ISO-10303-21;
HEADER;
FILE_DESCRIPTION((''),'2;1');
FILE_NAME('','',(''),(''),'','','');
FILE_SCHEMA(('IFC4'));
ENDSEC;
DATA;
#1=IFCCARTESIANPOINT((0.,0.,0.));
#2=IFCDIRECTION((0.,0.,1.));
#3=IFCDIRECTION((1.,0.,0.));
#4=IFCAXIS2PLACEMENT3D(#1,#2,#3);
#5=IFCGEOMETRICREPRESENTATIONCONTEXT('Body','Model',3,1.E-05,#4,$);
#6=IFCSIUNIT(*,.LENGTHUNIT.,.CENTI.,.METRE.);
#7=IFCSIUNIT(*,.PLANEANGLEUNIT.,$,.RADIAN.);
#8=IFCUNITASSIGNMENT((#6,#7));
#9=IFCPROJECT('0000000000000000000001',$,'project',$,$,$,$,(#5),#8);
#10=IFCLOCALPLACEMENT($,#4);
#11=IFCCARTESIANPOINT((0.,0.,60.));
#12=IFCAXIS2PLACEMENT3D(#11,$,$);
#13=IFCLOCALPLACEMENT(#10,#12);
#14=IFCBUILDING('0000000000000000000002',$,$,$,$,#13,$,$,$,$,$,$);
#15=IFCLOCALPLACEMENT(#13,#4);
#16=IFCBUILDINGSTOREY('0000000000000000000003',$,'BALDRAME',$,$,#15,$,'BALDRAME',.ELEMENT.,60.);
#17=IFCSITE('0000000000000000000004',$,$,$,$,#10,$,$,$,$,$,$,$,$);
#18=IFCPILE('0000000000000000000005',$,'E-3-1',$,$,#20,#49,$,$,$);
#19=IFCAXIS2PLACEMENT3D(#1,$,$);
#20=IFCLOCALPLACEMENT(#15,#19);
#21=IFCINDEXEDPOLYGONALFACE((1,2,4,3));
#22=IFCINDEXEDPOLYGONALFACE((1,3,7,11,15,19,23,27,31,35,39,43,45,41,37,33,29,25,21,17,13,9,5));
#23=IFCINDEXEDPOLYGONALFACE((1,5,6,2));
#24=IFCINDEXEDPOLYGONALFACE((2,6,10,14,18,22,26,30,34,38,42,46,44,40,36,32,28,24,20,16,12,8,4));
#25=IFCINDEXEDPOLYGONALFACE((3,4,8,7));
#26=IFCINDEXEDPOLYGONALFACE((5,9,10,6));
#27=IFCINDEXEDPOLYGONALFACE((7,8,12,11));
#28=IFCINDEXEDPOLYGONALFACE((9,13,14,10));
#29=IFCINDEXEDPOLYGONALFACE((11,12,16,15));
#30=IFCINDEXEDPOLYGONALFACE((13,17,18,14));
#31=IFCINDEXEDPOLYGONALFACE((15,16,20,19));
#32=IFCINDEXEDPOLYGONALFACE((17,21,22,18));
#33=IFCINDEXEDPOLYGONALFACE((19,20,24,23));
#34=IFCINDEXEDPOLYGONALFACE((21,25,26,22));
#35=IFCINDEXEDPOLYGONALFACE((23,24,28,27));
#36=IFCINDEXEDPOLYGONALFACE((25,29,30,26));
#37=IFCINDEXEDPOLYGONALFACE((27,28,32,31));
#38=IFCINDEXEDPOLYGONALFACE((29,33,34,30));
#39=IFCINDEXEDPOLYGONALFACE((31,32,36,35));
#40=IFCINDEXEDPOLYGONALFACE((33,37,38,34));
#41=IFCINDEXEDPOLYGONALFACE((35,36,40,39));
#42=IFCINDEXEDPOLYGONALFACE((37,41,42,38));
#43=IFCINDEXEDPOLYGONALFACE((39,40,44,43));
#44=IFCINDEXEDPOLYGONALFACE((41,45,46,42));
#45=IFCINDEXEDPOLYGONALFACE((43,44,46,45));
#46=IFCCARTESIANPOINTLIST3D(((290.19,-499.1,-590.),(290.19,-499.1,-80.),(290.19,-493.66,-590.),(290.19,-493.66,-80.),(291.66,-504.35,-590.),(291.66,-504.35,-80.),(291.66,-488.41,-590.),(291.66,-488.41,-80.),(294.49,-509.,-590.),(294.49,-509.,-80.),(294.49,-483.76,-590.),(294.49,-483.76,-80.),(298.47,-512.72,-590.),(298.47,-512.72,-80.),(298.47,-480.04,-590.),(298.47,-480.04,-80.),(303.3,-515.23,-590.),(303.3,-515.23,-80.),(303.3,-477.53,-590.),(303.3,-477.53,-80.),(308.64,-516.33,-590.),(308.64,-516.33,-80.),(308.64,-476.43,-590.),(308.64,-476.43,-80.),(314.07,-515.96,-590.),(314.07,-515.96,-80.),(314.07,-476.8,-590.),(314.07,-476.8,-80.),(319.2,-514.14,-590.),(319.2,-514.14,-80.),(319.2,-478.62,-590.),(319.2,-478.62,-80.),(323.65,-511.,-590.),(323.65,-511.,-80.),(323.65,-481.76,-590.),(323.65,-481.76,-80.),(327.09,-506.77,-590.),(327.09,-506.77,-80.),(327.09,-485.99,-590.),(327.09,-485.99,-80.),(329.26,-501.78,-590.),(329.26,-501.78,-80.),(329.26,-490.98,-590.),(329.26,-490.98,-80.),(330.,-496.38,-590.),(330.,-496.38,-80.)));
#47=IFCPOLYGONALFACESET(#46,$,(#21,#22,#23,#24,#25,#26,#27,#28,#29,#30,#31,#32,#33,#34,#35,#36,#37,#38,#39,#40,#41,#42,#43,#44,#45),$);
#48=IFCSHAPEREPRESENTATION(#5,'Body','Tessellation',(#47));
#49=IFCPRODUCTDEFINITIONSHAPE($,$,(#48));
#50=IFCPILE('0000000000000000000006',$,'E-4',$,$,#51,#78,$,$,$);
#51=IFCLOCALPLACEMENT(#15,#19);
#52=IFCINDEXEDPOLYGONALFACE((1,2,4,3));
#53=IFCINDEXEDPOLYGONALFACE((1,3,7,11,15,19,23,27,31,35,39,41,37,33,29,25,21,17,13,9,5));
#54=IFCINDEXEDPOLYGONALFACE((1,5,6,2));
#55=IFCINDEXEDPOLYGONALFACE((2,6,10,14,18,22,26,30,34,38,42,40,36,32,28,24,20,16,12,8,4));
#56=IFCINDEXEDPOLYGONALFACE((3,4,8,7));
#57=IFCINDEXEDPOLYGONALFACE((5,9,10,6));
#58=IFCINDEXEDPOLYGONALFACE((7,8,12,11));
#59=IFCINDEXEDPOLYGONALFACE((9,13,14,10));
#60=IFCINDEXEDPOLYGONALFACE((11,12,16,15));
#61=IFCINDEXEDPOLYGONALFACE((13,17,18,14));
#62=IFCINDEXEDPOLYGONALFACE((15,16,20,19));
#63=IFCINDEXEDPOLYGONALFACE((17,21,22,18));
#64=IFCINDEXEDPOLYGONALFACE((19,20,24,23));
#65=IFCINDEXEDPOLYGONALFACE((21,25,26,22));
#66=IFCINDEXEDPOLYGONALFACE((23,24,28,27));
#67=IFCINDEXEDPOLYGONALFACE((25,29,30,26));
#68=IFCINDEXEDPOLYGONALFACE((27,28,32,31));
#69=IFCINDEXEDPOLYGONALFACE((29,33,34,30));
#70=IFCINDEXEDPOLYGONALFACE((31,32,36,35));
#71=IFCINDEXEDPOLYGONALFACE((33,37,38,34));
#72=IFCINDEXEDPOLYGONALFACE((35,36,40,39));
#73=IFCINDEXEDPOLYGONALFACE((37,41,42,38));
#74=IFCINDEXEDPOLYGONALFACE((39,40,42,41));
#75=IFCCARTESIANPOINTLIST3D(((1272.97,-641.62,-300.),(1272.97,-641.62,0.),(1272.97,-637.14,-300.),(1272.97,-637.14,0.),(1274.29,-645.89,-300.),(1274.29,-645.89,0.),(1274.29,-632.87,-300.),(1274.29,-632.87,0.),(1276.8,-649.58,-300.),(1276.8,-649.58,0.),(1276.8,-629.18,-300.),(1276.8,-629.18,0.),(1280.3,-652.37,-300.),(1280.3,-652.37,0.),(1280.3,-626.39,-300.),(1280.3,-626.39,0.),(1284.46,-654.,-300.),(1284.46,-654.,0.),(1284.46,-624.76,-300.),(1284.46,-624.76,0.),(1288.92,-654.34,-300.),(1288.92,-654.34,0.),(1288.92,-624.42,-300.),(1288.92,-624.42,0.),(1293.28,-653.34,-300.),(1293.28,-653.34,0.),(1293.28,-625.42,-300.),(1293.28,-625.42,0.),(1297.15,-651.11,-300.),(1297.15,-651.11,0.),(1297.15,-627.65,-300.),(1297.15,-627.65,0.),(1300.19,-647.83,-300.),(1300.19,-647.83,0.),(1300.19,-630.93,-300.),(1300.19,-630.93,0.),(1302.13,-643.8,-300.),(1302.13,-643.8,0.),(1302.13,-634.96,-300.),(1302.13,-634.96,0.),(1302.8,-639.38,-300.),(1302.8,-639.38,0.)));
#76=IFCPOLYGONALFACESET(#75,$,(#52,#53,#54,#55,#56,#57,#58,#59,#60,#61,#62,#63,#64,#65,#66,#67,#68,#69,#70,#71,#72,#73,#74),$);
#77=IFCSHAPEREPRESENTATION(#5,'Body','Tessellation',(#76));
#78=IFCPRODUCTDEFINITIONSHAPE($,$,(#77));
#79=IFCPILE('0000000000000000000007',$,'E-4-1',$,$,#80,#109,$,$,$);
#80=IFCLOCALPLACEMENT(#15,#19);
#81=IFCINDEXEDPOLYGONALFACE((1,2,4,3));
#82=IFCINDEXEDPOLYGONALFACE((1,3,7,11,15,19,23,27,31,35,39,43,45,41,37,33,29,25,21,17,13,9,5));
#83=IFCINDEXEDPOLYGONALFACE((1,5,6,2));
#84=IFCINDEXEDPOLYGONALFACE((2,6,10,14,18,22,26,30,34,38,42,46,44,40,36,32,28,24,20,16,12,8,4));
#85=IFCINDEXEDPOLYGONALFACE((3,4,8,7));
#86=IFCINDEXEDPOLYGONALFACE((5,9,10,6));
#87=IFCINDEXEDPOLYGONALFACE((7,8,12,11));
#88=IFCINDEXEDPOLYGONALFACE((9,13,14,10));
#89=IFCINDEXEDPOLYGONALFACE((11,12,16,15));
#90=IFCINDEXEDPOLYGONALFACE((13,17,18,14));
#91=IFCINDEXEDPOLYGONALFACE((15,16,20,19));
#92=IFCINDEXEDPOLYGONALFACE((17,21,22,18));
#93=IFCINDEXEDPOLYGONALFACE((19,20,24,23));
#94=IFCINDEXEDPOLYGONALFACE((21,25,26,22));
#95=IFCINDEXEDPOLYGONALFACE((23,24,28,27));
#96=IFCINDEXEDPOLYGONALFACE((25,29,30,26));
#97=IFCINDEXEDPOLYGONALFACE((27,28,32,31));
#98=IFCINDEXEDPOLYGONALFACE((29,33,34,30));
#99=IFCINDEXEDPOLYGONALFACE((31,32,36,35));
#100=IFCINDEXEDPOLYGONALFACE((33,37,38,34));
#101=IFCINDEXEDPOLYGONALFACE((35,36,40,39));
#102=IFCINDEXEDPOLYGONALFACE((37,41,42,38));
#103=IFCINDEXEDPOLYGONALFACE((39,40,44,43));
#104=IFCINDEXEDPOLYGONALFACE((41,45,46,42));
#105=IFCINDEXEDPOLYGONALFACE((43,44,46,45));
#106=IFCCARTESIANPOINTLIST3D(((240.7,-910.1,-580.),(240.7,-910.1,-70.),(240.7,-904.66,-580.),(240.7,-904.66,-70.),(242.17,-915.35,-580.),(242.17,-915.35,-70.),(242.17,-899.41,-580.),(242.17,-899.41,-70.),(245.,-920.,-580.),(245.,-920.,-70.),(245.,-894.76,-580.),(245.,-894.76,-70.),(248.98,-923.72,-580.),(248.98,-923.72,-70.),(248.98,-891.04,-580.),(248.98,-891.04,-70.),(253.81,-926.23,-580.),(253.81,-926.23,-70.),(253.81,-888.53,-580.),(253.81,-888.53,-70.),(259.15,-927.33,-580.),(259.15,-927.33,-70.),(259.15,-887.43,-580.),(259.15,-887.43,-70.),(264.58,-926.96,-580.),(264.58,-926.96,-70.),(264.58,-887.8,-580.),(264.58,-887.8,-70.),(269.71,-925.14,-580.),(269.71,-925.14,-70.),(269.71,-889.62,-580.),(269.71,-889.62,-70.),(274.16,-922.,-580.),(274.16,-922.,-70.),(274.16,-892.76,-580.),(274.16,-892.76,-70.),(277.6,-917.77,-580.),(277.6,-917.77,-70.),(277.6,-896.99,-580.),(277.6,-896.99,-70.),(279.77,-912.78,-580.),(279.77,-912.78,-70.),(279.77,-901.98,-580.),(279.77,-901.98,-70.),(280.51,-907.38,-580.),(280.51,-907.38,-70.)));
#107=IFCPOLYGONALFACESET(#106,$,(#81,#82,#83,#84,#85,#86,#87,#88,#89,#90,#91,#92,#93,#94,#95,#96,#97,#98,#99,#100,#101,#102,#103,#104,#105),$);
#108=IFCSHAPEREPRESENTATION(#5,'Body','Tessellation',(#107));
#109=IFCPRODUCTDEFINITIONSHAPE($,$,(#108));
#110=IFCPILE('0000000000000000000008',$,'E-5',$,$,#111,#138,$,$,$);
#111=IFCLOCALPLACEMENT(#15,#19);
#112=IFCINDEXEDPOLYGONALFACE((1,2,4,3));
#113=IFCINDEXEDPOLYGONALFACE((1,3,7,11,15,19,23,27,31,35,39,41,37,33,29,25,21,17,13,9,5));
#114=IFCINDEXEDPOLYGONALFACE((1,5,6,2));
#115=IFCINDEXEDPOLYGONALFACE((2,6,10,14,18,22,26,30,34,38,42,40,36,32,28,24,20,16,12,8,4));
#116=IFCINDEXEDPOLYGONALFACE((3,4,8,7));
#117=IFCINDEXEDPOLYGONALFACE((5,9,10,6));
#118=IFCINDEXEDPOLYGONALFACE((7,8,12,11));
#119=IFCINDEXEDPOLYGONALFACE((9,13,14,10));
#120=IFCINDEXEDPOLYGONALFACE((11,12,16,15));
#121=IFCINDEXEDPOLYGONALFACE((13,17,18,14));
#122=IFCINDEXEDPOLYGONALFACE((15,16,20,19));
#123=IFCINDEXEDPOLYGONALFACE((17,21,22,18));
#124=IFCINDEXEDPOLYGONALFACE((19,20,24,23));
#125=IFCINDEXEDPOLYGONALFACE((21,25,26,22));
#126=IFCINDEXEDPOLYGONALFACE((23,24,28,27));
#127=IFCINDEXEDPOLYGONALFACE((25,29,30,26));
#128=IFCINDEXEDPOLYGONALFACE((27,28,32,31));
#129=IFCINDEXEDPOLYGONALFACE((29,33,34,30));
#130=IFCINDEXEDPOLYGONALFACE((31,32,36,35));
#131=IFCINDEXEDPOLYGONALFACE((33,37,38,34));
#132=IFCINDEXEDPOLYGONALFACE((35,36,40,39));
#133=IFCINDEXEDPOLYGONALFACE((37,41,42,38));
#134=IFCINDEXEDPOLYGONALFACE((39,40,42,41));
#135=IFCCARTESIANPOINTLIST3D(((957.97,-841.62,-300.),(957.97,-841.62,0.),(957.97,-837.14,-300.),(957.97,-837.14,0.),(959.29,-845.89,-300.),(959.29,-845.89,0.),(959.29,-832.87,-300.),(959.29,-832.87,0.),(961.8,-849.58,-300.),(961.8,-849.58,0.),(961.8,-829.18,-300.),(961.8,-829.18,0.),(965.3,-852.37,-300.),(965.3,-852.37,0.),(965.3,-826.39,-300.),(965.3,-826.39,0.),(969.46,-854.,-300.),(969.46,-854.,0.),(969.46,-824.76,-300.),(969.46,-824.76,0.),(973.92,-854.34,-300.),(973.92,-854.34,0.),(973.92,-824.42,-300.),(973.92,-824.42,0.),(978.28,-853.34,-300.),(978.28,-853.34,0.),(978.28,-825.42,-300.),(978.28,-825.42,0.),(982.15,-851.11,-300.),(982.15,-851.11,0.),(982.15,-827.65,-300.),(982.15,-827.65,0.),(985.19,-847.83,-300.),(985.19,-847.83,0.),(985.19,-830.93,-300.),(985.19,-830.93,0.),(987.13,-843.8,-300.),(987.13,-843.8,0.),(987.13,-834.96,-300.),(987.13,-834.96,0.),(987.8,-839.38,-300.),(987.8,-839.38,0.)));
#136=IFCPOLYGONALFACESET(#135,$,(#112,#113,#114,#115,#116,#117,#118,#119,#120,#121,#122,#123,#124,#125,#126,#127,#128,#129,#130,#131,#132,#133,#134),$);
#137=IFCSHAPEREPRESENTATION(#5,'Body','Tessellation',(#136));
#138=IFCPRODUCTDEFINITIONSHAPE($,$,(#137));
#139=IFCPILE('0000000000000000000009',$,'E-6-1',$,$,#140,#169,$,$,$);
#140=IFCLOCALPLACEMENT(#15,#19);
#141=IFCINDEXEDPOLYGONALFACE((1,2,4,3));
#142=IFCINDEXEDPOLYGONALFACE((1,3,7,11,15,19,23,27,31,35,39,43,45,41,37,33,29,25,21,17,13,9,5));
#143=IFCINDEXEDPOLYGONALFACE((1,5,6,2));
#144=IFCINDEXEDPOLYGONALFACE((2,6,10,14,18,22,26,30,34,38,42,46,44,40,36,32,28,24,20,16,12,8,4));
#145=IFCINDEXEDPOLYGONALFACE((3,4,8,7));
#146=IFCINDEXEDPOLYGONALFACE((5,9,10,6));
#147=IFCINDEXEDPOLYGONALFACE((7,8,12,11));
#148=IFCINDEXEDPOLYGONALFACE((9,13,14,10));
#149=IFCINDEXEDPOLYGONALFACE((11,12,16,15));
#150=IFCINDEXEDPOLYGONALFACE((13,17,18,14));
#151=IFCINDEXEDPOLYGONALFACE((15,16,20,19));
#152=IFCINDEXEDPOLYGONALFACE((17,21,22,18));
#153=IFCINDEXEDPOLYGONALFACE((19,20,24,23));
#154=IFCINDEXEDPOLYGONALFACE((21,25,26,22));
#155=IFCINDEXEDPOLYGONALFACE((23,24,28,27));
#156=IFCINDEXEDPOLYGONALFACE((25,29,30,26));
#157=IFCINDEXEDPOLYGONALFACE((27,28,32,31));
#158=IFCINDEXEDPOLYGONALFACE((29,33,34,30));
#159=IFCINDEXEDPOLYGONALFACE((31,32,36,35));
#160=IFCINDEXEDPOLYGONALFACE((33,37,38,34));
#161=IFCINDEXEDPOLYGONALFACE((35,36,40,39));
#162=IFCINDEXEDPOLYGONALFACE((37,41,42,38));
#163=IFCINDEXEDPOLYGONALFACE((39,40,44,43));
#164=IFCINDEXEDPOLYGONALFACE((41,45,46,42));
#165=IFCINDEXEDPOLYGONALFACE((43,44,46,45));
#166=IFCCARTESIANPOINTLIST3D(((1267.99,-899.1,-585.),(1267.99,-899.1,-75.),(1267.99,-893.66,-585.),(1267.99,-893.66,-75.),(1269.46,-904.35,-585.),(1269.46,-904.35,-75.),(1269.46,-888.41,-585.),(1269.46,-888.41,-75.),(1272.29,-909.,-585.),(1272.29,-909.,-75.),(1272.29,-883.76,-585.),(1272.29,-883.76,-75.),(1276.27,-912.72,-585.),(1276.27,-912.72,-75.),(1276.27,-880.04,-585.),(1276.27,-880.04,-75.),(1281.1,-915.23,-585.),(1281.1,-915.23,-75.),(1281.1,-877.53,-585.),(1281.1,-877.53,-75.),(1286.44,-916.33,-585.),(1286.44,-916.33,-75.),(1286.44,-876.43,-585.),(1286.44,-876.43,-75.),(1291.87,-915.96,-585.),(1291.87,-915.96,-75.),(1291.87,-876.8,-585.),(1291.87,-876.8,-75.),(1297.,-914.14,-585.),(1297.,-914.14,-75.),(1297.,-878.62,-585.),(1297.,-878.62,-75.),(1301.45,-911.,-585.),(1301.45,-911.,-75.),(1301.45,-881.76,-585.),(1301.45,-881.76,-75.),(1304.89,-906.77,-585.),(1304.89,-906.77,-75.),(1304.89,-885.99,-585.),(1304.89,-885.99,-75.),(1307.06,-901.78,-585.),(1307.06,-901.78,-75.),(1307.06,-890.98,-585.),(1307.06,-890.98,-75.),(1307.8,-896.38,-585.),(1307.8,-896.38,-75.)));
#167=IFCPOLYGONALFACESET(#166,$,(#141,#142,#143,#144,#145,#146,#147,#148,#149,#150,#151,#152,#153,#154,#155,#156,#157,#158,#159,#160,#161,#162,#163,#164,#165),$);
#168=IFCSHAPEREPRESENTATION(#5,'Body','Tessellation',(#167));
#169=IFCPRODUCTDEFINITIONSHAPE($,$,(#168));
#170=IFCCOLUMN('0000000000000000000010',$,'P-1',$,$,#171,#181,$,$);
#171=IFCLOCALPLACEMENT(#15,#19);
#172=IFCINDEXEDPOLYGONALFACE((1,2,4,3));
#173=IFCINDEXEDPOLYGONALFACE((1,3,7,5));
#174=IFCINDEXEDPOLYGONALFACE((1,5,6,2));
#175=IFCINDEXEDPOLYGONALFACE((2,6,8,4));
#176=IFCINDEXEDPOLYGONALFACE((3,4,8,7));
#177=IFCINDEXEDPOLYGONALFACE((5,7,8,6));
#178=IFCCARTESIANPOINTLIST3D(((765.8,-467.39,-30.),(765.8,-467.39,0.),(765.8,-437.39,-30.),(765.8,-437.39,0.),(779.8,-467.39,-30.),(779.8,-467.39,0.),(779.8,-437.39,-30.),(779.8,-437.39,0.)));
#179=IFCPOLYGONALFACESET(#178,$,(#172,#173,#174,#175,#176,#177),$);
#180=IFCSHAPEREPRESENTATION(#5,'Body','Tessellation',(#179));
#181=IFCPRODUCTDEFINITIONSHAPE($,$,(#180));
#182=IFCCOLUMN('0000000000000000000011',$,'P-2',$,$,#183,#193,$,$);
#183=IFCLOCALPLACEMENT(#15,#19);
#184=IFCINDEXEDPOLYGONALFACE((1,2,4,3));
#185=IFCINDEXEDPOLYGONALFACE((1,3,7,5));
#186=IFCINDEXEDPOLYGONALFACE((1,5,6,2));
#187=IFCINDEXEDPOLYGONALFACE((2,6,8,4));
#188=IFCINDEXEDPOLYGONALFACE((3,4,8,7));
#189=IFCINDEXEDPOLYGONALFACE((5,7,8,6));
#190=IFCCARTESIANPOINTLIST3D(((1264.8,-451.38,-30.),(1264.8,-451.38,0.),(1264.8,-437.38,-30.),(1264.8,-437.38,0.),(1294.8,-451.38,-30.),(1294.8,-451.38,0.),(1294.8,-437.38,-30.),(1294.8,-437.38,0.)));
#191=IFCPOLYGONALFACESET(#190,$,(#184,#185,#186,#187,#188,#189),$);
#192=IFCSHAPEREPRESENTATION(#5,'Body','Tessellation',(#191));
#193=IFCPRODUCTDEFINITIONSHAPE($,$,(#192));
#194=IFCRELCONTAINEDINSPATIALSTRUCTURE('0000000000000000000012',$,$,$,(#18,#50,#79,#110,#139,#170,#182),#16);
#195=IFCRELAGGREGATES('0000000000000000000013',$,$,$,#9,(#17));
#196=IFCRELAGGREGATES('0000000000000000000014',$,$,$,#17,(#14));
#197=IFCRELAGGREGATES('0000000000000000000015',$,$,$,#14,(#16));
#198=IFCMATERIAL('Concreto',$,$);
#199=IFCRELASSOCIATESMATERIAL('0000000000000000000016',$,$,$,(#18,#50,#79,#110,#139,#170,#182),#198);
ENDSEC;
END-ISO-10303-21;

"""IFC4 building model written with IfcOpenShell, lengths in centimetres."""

from ifc_helpers import new_model, si_unit, frame, origin_with_axes, origin_2d_with_axis, place, context, project, spatial, rectangle, circle, extrude, material, element, save


model = new_model("IFC4")

# Units and contexts
model_context = context("Model", 3, precision=1e-05, world=origin_with_axes(), identifier="Body")
ifc_project = project(units=[si_unit("LENGTHUNIT", "METRE", prefix="CENTI"), si_unit("PLANEANGLEUNIT", "RADIAN")], contexts=[model_context])

# Site, building, storey
site_placement = place(None, origin_with_axes())
site = spatial("IfcSite", under=ifc_project, at=site_placement)
building_placement = place(site_placement, frame((0.0, 0.0, 60.0)))
building = spatial("IfcBuilding", under=site, at=building_placement)
storey_placement = place(building_placement, origin_with_axes())
storey = spatial("IfcBuildingStorey", under=building, at=storey_placement, Name="BALDRAME", LongName="BALDRAME", CompositionType="ELEMENT", Elevation=60.0)

# Piles
ifc_material = material(Name="Concreto")
pile_1_placement = place(storey_placement, frame((310.0, -496.38, -80.0), z_axis=(0.0, 0.0, 1.0), x_axis=(1.0, 0.0, 0.0)))
element("IfcPile", 1, at=pile_1_placement, inside=storey, material=ifc_material, Name="E-3-1", context=model_context, shape_type="SweptSolid", body=[
    extrude(circle(Radius=20.0, at=origin_2d_with_axis()), frame((0.0, 0.0, -510.0), z_axis=(0.0, 0.0, 1.0), x_axis=(1.0, 0.0, 0.0)), (0.0, 0.0, 1.0), 510.0),
])
pile_2_placement = place(storey_placement, frame((1287.8, -639.38, 0.0), z_axis=(0.0, 0.0, 1.0), x_axis=(1.0, 0.0, 0.0)))
element("IfcPile", 2, at=pile_2_placement, inside=storey, material=ifc_material, Name="E-4", context=model_context, shape_type="SolidModel", body=[
    extrude(circle(Radius=15.0, at=origin_2d_with_axis()), frame((0.0, 0.0, -300.0), z_axis=(0.0, 0.0, 1.0), x_axis=(1.0, 0.0, 0.0)), (0.0, 0.0, 1.0), 300.0),
])
pile_3_placement = place(storey_placement, frame((260.51, -907.38, -70.0), z_axis=(0.0, 0.0, 1.0), x_axis=(1.0, 0.0, 0.0)))
element("IfcPile", 3, at=pile_3_placement, inside=storey, material=ifc_material, Name="E-4-1", context=model_context, shape_type="SweptSolid", body=[
    extrude(circle(Radius=20.0, at=origin_2d_with_axis()), frame((0.0, 0.0, -510.0), z_axis=(0.0, 0.0, 1.0), x_axis=(1.0, 0.0, 0.0)), (0.0, 0.0, 1.0), 510.0),
])
pile_4_placement = place(storey_placement, frame((972.8, -839.38, 0.0), z_axis=(0.0, 0.0, 1.0), x_axis=(1.0, 0.0, 0.0)))
element("IfcPile", 4, at=pile_4_placement, inside=storey, material=ifc_material, Name="E-5", context=model_context, shape_type="SolidModel", body=[
    extrude(circle(Radius=15.0, at=origin_2d_with_axis()), frame((0.0, 0.0, -300.0), z_axis=(0.0, 0.0, 1.0), x_axis=(1.0, 0.0, 0.0)), (0.0, 0.0, 1.0), 300.0),
])
pile_5_placement = place(storey_placement, frame((1287.8, -896.38, -75.0), z_axis=(0.0, 0.0, 1.0), x_axis=(1.0, 0.0, 0.0)))
element("IfcPile", 5, at=pile_5_placement, inside=storey, material=ifc_material, Name="E-6-1", context=model_context, shape_type="SweptSolid", body=[
    extrude(circle(Radius=20.0, at=origin_2d_with_axis()), frame((0.0, 0.0, -510.0), z_axis=(0.0, 0.0, 1.0), x_axis=(1.0, 0.0, 0.0)), (0.0, 0.0, 1.0), 510.0),
])

# Columns
column_1_placement = place(storey_placement, frame((772.8, -452.39, 0.0), z_axis=(0.0, 0.0, 1.0), x_axis=(1.0, 0.0, 0.0)))
element("IfcColumn", 6, at=column_1_placement, inside=storey, material=ifc_material, Name="P-1", context=model_context, shape_type="SolidModel", body=[
    extrude(rectangle(XDim=14.0, YDim=30.0, at=origin_2d_with_axis()), frame((0.0, 0.0, -30.0), z_axis=(0.0, 0.0, 1.0), x_axis=(1.0, 0.0, 0.0)), (0.0, 0.0, 1.0), 30.0),
])
column_2_placement = place(storey_placement, frame((1279.8, -444.38, 0.0), z_axis=(0.0, 0.0, 1.0), x_axis=(1.0, 0.0, 0.0)))
element("IfcColumn", 7, at=column_2_placement, inside=storey, material=ifc_material, Name="P-2", context=model_context, shape_type="SolidModel", body=[
    extrude(rectangle(XDim=14.0, YDim=30.0, at=origin_2d_with_axis()), frame((0.0, 0.0, -30.0), z_axis=(0.0, 0.0, 1.0), x_axis=(0.0, -1.0, 0.0)), (0.0, 0.0, 1.0), 30.0),
])

save(model, "model.ifc")
